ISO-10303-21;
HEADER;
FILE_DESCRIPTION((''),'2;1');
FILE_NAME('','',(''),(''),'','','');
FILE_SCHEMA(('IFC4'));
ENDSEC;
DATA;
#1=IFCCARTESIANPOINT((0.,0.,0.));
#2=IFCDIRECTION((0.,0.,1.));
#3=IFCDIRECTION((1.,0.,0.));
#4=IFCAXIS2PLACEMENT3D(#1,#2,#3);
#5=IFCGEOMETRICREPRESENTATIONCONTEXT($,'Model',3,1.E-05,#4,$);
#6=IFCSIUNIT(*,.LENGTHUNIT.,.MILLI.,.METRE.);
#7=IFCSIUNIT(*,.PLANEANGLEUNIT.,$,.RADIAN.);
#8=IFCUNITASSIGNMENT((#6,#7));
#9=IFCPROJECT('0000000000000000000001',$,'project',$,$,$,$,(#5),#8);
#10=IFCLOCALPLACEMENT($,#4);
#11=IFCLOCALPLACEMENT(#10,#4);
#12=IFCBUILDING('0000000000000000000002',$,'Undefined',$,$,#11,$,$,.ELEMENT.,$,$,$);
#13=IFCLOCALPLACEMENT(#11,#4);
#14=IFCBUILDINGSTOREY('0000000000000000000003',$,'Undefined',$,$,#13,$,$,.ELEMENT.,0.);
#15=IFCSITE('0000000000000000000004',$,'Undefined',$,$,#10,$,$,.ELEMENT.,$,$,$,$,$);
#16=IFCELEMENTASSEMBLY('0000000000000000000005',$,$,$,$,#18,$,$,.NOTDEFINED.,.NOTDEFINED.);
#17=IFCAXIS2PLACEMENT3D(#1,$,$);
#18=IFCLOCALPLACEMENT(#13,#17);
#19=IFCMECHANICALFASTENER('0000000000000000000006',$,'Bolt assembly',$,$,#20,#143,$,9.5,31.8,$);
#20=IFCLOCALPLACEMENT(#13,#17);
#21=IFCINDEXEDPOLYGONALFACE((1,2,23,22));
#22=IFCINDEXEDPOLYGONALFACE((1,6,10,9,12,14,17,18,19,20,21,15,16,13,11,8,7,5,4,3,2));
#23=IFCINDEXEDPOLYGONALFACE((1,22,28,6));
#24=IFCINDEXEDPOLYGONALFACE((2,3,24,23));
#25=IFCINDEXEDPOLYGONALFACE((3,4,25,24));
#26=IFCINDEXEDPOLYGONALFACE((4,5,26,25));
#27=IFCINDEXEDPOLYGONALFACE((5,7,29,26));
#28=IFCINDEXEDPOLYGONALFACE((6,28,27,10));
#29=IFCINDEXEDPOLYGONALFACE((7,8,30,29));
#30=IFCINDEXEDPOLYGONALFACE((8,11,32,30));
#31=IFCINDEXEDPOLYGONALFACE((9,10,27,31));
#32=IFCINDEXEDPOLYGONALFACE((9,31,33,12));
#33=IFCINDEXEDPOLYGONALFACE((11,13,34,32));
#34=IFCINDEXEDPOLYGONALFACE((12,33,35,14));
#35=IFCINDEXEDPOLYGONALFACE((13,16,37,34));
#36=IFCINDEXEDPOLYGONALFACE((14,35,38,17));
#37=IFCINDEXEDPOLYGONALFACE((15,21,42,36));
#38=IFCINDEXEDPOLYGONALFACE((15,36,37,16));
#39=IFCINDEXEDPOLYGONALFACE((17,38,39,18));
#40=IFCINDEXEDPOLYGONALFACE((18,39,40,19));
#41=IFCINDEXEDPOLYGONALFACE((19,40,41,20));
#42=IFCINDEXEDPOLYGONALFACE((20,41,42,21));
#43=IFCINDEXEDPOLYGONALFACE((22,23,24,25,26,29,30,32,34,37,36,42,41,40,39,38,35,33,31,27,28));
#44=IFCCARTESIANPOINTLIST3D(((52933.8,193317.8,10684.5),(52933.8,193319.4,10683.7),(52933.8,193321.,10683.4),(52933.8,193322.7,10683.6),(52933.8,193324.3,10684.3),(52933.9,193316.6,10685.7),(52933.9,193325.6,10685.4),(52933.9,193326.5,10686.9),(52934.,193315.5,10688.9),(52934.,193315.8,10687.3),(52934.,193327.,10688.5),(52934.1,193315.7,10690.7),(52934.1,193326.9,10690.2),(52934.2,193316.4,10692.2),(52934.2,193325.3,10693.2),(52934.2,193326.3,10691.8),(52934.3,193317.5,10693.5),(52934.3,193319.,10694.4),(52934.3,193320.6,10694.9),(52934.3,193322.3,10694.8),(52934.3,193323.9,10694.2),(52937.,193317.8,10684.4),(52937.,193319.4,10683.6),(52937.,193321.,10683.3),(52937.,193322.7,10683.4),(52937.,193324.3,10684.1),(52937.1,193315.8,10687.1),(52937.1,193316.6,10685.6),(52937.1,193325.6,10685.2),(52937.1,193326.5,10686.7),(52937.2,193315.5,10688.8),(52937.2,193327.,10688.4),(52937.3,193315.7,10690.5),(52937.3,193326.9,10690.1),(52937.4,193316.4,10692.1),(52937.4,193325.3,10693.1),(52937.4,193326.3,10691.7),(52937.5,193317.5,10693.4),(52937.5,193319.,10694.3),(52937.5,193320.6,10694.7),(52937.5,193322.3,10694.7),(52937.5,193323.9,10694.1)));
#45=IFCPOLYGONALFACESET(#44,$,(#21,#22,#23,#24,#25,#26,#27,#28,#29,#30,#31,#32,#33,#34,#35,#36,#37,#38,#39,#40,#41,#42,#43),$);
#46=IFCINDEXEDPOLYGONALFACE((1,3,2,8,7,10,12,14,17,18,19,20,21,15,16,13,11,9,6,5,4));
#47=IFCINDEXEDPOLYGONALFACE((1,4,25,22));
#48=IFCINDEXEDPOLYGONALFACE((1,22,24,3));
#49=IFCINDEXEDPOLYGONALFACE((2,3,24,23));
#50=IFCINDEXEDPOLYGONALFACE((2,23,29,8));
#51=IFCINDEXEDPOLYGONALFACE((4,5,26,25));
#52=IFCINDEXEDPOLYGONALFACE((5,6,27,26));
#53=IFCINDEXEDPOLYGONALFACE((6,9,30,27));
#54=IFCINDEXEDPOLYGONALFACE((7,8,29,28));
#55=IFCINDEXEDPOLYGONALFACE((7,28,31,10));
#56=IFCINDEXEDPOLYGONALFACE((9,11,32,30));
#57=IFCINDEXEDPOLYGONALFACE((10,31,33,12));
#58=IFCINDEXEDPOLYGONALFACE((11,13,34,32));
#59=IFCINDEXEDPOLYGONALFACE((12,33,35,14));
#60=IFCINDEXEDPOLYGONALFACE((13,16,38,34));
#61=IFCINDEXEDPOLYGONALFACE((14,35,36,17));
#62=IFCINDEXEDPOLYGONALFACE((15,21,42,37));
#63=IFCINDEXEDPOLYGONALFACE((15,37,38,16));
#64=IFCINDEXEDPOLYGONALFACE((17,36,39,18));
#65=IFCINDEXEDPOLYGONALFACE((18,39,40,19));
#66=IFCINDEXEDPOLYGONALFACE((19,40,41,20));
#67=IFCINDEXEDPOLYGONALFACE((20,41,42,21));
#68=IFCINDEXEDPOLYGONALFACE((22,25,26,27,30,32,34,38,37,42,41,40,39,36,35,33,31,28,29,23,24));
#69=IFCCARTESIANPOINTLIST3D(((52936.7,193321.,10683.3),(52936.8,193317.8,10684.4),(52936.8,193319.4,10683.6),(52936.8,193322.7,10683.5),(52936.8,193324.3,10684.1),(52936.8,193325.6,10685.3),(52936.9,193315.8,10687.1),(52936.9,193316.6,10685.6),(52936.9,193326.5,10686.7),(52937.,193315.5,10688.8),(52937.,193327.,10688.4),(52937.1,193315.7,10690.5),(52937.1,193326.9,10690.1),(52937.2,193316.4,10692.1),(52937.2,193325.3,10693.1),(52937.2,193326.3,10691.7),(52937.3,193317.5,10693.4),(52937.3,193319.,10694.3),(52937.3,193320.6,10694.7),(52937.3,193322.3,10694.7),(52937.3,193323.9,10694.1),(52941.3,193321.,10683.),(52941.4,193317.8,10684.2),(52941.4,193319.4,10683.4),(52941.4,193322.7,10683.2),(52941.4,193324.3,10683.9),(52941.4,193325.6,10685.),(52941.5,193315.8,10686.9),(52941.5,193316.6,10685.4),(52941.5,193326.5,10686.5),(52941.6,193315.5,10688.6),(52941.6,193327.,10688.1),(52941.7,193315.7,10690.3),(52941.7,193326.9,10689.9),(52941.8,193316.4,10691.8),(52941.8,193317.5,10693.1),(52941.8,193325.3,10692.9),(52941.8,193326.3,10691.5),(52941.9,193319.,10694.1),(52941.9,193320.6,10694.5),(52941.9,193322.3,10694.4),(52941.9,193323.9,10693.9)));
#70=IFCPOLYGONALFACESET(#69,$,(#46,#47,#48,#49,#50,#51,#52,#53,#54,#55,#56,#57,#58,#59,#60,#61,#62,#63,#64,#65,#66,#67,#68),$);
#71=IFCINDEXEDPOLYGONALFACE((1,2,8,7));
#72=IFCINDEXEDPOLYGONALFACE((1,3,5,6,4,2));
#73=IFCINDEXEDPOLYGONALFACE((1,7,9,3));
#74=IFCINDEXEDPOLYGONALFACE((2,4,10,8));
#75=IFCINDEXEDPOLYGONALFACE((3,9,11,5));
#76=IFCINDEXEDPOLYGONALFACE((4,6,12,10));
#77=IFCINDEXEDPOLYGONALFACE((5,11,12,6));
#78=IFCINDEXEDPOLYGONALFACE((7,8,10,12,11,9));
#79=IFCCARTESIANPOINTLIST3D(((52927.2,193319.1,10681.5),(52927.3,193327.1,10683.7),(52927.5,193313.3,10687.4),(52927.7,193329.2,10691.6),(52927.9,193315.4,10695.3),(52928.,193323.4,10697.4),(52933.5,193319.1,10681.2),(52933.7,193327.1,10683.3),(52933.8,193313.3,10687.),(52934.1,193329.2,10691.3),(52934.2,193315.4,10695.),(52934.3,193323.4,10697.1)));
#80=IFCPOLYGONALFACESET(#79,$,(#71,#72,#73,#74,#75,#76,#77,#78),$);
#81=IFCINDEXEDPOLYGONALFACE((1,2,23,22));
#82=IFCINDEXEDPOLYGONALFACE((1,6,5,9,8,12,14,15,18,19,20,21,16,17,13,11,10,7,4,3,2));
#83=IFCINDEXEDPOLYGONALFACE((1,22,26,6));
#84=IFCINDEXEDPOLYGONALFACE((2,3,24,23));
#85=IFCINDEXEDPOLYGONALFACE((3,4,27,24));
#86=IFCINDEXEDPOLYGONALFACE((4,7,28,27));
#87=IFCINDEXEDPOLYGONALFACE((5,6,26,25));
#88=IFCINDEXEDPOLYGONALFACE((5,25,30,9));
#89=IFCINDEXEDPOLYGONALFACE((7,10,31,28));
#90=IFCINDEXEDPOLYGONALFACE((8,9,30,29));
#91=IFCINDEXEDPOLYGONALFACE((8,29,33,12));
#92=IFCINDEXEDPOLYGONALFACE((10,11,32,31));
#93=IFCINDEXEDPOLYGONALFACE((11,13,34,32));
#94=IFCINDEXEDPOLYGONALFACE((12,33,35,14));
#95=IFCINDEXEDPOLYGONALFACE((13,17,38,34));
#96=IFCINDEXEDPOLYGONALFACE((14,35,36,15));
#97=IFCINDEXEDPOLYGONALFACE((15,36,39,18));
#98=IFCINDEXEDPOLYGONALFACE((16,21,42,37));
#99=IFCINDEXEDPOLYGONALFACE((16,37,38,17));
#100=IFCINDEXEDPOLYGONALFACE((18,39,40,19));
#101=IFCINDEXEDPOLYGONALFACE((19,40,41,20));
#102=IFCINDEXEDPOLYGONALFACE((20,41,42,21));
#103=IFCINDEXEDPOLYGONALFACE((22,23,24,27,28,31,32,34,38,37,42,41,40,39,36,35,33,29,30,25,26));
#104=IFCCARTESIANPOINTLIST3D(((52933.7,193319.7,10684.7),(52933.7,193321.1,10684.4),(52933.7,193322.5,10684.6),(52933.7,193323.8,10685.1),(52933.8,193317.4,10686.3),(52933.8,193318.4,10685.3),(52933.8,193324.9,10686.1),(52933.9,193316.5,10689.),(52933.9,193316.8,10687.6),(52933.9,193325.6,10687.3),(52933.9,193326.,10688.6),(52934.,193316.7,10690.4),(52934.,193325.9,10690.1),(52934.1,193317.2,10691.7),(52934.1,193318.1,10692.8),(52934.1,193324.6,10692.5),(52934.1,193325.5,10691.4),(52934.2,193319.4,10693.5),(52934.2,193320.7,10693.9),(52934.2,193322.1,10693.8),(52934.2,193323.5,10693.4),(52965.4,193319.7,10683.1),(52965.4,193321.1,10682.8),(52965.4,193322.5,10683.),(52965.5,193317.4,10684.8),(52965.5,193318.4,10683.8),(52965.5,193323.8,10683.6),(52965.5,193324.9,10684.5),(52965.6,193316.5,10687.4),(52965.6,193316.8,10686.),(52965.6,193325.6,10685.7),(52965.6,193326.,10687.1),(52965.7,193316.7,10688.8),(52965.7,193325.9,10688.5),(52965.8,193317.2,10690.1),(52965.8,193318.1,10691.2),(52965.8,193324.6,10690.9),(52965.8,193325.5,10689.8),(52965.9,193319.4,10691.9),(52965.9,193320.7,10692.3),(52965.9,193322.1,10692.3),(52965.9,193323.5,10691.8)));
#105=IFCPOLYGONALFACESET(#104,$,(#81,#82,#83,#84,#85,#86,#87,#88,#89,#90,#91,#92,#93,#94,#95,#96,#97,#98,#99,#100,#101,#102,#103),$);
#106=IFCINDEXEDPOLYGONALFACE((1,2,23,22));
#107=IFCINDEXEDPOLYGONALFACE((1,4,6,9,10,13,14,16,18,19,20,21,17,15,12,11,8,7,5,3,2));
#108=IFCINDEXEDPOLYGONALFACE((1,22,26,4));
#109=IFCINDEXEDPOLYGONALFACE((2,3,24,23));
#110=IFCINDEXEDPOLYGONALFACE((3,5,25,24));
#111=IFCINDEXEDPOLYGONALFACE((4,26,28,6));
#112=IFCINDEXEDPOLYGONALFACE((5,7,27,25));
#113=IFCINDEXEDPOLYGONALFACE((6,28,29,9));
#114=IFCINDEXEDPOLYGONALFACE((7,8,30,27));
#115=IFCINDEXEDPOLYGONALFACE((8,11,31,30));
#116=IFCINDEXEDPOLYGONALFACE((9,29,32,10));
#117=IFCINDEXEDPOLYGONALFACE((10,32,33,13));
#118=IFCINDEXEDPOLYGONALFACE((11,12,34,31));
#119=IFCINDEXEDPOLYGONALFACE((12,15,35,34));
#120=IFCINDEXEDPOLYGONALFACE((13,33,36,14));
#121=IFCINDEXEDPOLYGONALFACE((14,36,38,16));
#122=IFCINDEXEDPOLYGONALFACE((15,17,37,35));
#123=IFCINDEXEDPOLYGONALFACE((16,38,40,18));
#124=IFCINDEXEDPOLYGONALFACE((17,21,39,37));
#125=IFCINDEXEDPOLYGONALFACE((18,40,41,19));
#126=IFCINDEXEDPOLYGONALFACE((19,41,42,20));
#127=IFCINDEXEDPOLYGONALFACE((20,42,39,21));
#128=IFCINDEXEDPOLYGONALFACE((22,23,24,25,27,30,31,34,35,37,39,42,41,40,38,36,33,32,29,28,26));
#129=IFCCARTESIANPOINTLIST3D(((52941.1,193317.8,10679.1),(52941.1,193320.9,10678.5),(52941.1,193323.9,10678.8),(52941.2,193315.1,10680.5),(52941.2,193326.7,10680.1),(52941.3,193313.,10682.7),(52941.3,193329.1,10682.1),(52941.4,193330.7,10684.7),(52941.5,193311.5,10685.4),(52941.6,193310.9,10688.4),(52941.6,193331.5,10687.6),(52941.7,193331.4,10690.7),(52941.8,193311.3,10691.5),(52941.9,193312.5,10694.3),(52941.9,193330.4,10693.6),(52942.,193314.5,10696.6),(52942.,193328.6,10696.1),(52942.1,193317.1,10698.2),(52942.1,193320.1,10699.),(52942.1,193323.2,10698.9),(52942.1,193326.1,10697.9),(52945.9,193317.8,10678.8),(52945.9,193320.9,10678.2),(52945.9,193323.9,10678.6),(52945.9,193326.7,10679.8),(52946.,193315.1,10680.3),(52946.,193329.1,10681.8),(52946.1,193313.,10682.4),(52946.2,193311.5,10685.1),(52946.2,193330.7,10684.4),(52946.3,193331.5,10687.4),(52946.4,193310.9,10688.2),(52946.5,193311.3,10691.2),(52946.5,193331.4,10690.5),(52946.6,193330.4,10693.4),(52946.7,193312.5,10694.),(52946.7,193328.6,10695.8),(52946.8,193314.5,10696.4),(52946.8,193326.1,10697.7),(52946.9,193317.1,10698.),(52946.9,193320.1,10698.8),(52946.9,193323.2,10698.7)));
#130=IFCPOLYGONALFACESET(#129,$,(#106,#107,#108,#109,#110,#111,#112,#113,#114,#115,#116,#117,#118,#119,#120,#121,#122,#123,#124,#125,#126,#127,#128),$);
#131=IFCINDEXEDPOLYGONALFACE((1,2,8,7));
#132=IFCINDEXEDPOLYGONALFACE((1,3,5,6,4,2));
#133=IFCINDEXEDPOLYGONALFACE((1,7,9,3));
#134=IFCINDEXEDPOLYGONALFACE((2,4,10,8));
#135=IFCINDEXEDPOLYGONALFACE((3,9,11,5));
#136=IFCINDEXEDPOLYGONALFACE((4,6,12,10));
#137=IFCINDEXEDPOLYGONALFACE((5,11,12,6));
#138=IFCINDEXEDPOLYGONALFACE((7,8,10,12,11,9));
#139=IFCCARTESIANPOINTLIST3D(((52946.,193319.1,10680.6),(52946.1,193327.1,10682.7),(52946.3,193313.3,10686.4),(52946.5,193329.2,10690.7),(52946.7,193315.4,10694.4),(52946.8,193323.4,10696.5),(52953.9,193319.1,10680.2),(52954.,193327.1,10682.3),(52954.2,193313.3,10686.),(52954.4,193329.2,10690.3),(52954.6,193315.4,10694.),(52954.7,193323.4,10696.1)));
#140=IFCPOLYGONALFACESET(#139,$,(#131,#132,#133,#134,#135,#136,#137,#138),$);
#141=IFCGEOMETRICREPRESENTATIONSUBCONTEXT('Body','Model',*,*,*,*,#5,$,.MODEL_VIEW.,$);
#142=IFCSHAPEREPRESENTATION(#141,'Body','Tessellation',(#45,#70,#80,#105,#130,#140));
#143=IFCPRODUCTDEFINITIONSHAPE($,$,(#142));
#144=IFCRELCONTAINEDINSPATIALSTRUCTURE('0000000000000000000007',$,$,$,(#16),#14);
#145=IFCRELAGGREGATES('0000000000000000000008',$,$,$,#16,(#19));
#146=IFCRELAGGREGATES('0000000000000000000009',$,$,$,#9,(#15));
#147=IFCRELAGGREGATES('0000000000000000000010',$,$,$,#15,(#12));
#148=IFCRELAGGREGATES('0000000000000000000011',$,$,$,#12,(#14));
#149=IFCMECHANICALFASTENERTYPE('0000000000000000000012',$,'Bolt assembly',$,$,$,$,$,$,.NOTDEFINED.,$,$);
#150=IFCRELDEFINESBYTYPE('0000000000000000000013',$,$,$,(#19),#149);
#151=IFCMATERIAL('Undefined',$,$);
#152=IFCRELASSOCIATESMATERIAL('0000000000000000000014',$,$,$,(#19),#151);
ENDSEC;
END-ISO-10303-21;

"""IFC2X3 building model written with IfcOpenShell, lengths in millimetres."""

from ifc_helpers import new_model, si_unit, frame, origin_with_axes, origin_2d_with_axis, place, context, subcontext, project, spatial, polyline, circle, outline, extrude, source, transform, mapped, material, type_object, element, aggregate, save


model = new_model("IFC2X3")

# Units and contexts
model_context = context("Model", 3, precision=1e-05, world=origin_with_axes())
body_context = subcontext(model_context, "Body", "Model", "MODEL_VIEW")
ifc_project = project(units=[si_unit("LENGTHUNIT", "METRE", prefix="MILLI"), si_unit("PLANEANGLEUNIT", "RADIAN")], contexts=[model_context])

# Site, building, storey
site_placement = place(None, origin_with_axes())
site = spatial("IfcSite", under=ifc_project, at=site_placement, Name="Undefined", CompositionType="ELEMENT")
building_placement = place(site_placement, origin_with_axes())
building = spatial("IfcBuilding", under=site, at=building_placement, Name="Undefined", CompositionType="ELEMENT")
storey_placement = place(building_placement, origin_with_axes())
storey = spatial("IfcBuildingStorey", under=building, at=storey_placement, Name="Undefined", CompositionType="ELEMENT", Elevation=0.0)

# Element assembly
assembly_1_placement = place(storey_placement, origin_with_axes())
assembly_1 = element("IfcElementAssembly", 1, at=assembly_1_placement, inside=storey, AssemblyPlace="NOTDEFINED", PredefinedType="NOTDEFINED")

# Mechanical fastener
ifc_material_1 = material(Name="Undefined")
mechanical_fastener_type = type_object("IfcMechanicalFastenerType", Name="Bolt assembly")
shared_shape_1 = source(origin_with_axes(), body_context, "Body", "SweptSolid", [
    extrude(circle(Radius=5.8, at=origin_2d_with_axis()), frame((0.0, -7.6, 0.0), z_axis=(0.0, 1.0, 0.0), x_axis=(1.0, 0.0, 0.0)), (0.0, 0.0, 1.0), 3.2),
    extrude(circle(Radius=5.8, at=origin_2d_with_axis()), frame((0.0, -4.6, 0.0), z_axis=(0.0, 1.0, 0.0), x_axis=(1.0, 0.0, 0.0)), (0.0, 0.0, 1.0), 4.6),
    extrude(outline(polyline([(7.1, -4.1), (7.1, 4.1), (0.0, 8.2), (-7.1, 4.1), (-7.1, -4.1), (0.0, -8.2), (7.1, -4.1)])), frame((0.0, -14.0, 0.0), z_axis=(0.0, 1.0, 0.0), x_axis=(1.0, 0.0, 0.0)), (0.0, 0.0, 1.0), 6.3),
    extrude(circle(Radius=4.8, at=origin_2d_with_axis()), frame((0.0, -7.7, 0.0), z_axis=(0.0, 1.0, 0.0), x_axis=(1.0, 0.0, 0.0)), (0.0, 0.0, 1.0), 31.8),
    extrude(circle(Radius=10.3, at=origin_2d_with_axis()), frame((0.0, 0.0, 0.0), z_axis=(0.0, 1.0, 0.0), x_axis=(1.0, 0.0, 0.0)), (0.0, 0.0, 1.0), 4.8),
    extrude(outline(polyline([(7.1, -4.1), (7.1, 4.1), (0.0, 8.2), (-7.1, 4.1), (-7.1, -4.1), (0.0, -8.2), (7.1, -4.1)])), frame((0.0, 4.8, 0.0), z_axis=(0.0, 1.0, 0.0), x_axis=(1.0, 0.0, 0.0)), (0.0, 0.0, 1.0), 7.9),
])
mechanical_fastener_1_placement = place(assembly_1_placement, frame((52941.6, 193321.3, 10688.8), z_axis=(-0.035282, 0.707107, -0.706226), x_axis=(0.035281, 0.707107, 0.706226)))
mechanical_fastener_1 = element("IfcMechanicalFastener", 2, at=mechanical_fastener_1_placement, type_object=mechanical_fastener_type, material=ifc_material_1, Name="Bolt assembly", NominalDiameter=9.5, NominalLength=31.8, context=body_context, shape_type="MappedRepresentation", body=[
    mapped(shared_shape_1, transform((0.0, 0.0, 0.0))),
])
aggregate(assembly_1, [mechanical_fastener_1])

save(model, "model.ifc")
